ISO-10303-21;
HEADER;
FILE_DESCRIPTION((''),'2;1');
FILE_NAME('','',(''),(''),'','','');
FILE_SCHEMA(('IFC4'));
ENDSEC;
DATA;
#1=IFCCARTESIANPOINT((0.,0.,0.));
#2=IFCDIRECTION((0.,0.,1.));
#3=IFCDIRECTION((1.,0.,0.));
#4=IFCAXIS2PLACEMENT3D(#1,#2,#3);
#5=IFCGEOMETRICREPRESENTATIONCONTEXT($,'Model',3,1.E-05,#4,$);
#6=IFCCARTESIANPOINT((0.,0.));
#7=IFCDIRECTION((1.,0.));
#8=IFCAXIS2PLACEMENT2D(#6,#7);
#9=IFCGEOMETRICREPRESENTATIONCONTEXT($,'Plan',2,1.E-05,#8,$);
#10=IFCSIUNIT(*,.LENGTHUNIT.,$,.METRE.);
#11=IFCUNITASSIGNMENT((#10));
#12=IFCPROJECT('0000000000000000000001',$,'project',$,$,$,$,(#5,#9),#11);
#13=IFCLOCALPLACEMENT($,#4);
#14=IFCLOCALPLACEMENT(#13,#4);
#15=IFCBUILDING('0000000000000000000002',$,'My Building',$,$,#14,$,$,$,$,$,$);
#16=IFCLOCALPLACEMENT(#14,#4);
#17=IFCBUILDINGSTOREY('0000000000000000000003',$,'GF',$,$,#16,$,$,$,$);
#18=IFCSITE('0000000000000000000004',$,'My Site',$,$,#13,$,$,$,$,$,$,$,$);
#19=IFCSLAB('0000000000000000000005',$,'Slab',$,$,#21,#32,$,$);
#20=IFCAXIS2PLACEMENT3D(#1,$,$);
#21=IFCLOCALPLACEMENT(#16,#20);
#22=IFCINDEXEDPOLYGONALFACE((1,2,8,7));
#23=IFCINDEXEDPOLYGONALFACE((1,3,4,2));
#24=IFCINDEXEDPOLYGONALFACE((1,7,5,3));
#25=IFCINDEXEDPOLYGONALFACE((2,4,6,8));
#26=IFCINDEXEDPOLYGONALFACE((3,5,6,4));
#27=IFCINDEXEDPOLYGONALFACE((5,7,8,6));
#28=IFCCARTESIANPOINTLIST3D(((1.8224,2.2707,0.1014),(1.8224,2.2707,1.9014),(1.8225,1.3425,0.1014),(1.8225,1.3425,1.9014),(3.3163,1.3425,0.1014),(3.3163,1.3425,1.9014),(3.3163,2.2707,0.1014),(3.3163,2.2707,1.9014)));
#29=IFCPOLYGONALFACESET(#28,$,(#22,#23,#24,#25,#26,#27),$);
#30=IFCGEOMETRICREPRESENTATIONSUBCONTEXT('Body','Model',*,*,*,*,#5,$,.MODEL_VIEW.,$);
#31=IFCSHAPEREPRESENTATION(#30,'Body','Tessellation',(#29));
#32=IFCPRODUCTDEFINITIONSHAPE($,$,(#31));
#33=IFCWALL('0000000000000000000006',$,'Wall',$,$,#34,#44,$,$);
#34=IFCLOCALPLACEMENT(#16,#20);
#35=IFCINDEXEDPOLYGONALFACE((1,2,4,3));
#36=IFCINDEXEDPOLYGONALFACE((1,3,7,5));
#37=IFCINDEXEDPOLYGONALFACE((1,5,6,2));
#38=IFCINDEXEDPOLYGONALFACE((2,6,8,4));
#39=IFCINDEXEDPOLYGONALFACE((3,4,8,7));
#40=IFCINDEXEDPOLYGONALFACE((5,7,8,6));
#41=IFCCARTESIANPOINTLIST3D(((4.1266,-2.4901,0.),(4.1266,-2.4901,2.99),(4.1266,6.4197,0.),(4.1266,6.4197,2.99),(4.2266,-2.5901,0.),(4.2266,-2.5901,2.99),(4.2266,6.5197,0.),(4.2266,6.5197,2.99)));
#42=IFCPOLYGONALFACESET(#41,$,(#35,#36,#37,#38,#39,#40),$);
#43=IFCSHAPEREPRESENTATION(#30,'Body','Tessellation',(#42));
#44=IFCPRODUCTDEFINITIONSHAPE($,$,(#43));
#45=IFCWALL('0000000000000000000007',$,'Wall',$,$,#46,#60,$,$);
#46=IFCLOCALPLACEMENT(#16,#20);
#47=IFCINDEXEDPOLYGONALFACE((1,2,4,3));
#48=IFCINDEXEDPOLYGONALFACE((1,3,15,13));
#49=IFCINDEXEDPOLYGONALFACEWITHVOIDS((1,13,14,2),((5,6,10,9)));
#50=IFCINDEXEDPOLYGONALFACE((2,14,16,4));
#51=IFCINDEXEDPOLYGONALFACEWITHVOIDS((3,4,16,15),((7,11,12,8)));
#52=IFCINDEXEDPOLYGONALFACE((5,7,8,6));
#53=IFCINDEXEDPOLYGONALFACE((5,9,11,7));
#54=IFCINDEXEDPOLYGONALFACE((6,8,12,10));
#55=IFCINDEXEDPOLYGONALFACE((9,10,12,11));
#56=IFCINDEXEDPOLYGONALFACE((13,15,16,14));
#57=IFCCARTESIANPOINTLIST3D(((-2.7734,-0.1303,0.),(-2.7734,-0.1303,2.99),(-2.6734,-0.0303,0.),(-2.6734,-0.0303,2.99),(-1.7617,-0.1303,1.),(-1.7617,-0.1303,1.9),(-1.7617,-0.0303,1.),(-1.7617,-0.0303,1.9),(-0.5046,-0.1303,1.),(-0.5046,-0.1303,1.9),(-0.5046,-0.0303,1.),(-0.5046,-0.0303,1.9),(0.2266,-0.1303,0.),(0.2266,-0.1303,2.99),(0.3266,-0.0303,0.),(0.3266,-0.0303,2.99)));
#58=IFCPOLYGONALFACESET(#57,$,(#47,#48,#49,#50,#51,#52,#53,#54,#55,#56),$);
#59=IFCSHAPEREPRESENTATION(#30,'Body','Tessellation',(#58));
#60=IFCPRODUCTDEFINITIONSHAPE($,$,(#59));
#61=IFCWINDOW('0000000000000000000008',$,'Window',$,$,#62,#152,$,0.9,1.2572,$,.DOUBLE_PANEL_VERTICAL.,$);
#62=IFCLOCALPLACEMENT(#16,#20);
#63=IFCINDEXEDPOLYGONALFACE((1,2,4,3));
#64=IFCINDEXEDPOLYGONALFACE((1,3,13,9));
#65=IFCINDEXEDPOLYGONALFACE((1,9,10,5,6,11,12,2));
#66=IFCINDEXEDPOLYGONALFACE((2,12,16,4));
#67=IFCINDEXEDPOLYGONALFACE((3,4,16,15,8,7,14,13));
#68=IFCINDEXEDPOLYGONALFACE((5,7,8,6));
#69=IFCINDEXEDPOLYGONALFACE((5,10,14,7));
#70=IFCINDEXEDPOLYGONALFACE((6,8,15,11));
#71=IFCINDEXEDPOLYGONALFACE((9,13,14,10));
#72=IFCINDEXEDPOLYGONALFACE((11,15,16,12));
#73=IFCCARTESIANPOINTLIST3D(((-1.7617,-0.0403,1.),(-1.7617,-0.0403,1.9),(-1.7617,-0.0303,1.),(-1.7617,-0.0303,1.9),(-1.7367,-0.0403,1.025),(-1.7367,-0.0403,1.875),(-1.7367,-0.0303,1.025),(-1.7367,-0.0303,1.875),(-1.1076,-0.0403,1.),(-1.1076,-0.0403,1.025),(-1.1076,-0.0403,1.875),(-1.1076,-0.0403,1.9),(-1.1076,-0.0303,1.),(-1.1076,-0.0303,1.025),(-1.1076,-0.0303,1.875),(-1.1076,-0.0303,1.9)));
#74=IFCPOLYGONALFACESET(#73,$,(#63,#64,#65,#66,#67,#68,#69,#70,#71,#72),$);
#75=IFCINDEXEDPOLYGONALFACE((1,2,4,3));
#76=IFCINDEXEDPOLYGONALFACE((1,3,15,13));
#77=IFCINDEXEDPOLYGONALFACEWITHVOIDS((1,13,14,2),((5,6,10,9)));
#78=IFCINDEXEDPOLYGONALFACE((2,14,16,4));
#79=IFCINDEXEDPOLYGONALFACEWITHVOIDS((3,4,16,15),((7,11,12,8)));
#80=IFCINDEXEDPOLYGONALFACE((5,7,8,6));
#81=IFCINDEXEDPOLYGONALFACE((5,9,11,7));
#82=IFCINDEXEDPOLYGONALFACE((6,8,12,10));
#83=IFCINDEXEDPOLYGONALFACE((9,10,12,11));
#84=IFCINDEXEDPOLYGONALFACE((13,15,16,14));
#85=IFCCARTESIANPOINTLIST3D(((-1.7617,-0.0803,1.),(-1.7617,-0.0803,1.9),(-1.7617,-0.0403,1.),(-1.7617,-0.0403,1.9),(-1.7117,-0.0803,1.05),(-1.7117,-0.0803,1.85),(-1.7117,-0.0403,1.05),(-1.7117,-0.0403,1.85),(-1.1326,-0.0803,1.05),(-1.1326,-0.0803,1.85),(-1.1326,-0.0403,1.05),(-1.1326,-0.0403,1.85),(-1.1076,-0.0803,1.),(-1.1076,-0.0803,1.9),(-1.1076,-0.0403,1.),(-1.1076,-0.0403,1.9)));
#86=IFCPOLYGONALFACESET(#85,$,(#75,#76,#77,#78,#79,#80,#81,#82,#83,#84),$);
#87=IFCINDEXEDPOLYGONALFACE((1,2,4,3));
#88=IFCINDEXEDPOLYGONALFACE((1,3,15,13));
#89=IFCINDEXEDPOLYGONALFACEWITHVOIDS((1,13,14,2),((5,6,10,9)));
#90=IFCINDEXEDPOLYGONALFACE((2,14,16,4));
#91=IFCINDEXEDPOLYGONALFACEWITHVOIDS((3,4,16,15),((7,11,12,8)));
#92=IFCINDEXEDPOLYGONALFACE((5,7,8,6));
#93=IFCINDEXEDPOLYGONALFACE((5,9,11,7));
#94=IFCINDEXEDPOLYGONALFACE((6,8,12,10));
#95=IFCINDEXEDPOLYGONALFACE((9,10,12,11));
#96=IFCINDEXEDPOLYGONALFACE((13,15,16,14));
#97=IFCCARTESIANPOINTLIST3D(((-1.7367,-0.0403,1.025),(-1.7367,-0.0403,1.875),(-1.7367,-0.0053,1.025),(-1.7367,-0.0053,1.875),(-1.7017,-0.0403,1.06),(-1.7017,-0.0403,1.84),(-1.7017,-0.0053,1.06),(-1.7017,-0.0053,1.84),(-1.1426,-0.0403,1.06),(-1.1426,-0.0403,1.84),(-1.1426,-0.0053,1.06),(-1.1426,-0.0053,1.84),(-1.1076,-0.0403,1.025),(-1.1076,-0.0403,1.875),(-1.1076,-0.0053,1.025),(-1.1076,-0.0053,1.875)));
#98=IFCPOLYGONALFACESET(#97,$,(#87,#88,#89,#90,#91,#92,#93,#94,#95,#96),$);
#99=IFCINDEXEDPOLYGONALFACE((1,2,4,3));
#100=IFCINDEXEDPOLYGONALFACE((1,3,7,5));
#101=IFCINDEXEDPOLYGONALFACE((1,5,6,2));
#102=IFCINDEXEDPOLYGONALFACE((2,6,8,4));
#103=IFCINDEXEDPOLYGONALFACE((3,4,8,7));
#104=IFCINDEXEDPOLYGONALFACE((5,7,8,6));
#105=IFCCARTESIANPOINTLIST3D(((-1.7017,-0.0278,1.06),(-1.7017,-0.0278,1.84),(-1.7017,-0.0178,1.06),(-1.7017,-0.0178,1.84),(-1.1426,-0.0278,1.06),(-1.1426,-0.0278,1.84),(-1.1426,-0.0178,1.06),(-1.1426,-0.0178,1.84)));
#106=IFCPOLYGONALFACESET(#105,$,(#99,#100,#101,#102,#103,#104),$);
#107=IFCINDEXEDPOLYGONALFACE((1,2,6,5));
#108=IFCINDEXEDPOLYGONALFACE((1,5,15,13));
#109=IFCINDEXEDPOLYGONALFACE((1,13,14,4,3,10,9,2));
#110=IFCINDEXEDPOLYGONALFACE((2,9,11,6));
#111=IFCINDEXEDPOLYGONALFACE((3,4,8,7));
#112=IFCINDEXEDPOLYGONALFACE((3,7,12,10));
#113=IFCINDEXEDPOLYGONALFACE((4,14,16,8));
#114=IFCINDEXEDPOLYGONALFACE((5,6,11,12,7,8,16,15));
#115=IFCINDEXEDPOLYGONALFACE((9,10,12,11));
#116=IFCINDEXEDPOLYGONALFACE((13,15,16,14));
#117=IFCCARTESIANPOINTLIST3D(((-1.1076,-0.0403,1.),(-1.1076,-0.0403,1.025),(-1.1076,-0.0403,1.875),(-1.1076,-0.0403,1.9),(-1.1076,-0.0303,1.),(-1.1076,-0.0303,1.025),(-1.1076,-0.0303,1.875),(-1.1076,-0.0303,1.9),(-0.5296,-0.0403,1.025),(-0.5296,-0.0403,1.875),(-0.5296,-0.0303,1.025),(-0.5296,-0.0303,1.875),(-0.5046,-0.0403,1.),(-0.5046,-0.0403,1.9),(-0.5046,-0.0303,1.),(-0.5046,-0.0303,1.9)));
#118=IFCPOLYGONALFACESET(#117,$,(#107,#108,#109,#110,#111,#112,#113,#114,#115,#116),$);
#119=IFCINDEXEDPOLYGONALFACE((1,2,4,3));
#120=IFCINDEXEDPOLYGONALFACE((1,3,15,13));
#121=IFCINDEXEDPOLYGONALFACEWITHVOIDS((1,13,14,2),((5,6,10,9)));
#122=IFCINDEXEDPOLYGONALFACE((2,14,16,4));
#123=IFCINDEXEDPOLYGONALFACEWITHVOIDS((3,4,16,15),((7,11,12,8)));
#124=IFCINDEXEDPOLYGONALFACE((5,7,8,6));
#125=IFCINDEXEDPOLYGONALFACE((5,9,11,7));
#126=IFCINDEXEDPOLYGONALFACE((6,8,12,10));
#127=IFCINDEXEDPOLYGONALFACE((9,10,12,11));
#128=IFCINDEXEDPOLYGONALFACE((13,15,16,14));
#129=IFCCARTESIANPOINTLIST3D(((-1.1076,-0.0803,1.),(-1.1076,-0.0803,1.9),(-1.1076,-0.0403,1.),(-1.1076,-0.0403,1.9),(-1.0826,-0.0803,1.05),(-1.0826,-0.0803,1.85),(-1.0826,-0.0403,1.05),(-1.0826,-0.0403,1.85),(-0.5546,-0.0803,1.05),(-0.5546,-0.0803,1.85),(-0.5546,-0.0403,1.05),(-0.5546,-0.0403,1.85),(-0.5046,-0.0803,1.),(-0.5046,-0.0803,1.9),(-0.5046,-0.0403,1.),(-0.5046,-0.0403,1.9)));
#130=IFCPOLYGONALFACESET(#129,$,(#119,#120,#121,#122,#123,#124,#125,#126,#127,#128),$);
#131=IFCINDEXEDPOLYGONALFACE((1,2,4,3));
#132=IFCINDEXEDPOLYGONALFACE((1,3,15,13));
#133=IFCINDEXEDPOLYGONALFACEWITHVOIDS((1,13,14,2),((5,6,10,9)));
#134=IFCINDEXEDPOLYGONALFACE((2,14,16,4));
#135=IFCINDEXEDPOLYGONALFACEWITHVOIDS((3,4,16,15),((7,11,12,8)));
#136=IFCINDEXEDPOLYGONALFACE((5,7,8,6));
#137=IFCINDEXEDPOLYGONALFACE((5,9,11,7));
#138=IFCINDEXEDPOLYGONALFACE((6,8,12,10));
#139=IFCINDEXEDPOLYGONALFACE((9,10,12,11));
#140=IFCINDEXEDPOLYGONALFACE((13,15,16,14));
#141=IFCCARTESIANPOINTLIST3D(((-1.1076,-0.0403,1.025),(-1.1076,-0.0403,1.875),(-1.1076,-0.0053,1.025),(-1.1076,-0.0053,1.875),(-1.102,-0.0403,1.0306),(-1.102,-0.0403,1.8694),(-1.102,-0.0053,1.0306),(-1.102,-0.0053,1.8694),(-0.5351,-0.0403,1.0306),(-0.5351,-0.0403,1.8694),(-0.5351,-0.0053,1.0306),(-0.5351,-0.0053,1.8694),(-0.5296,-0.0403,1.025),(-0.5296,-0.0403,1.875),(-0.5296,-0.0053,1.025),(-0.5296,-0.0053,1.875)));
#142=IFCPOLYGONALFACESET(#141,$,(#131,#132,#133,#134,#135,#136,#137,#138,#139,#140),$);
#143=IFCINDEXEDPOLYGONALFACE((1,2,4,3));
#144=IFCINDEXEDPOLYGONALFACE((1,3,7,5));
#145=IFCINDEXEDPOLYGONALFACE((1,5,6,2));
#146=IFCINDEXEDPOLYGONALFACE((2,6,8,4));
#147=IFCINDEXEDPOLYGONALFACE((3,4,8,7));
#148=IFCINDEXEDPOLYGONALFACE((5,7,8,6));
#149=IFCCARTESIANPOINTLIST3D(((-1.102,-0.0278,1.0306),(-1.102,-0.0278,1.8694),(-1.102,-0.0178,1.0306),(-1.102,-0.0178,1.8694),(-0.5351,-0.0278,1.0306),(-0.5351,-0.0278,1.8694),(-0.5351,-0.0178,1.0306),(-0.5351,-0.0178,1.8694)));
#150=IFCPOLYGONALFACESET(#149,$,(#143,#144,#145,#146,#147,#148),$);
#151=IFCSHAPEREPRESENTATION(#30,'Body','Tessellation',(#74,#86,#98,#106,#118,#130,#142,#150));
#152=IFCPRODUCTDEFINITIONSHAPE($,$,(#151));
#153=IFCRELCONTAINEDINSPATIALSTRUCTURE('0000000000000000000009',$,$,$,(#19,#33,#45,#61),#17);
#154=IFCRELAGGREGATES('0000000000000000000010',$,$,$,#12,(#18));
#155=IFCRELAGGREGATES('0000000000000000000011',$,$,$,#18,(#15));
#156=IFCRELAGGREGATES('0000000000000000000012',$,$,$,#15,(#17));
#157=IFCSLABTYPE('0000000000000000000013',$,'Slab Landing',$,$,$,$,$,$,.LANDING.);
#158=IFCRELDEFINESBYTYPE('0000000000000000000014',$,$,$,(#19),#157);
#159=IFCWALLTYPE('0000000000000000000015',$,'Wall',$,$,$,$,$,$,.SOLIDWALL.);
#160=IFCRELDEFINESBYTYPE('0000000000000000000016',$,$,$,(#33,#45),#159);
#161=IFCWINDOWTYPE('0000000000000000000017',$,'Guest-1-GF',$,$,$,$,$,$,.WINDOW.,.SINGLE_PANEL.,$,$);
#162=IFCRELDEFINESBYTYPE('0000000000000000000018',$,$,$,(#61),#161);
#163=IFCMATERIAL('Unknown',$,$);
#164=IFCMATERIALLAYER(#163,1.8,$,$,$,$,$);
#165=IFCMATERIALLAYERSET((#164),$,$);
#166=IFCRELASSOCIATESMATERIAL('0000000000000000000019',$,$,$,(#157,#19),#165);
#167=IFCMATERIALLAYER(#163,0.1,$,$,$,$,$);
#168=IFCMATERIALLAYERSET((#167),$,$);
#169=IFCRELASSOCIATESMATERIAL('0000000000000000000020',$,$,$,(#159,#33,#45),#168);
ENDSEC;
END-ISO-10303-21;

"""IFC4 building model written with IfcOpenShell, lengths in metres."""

from ifc_helpers import new_model, entity, si_unit, frame, origin_with_axes, origin_2d_with_axis, place, context, subcontext, project, spatial, line, indexed_curve, outline, extrude, shape, source, transform, mapped, material, layer, layer_set, layer_usage, type_object, type_shapes, element, fill, save


model = new_model("IFC4")

# Units and contexts
model_context = context("Model", 3, precision=1e-05, world=origin_with_axes())
plan_context = context("Plan", 2, precision=1e-05, world=origin_2d_with_axis())
body_context_1 = subcontext(model_context, "Body", "Model", "MODEL_VIEW")
body_context_2 = subcontext(plan_context, "Body", "Plan", "PLAN_VIEW")
ifc_project = project(units=[si_unit("LENGTHUNIT", "METRE")], contexts=[model_context, plan_context])

# Site, building, storey
site_placement = place(None, origin_with_axes())
site = spatial("IfcSite", under=ifc_project, at=site_placement, Name="My Site")
building_placement = place(site_placement, origin_with_axes())
building = spatial("IfcBuilding", under=site, at=building_placement, Name="My Building")
storey_placement = place(building_placement, origin_with_axes())
storey = spatial("IfcBuildingStorey", under=building, at=storey_placement, Name="GF")

# Shared definitions
ifc_material = material(Name="Unknown")

# Slab
ifc_layer_1 = layer(ifc_material, 1.8)
ifc_layer_set_1 = layer_set([ifc_layer_1])
slab_type_1 = type_object("IfcSlabType", Name="Slab Landing", PredefinedType="LANDING", material=ifc_layer_set_1)
ifc_layer_usage_1 = layer_usage(ifc_layer_set_1, "AXIS3", "POSITIVE", -1.8)
slab_1_placement = place(storey_placement, frame((1.8225, 1.3425, 1.9014), z_axis=(0.0, 0.0, 1.0), x_axis=(1.0, 0.0, 0.0)))
element("IfcSlab", 1, at=slab_1_placement, inside=storey, type_object=slab_type_1, material=ifc_layer_usage_1, Name="Slab", context=body_context_1, shape_type="SweptSolid", body=[
    extrude(outline(indexed_curve([(0.0, 0.0), (1.4938, 0.0), (1.4938, 0.9282), (0.0, 0.9282), (0.0, 0.0)])), frame((0.0, 0.0, -1.8), z_axis=(0.0, 0.0, 1.0), x_axis=(1.0, 0.0, 0.0)), (0.0, 0.0, 1.0), 1.8),
])

# Shared definitions
ifc_layer_2 = layer(ifc_material, 0.1)
ifc_layer_set_2 = layer_set([ifc_layer_2])
wall_type = type_object("IfcWallType", Name="Wall", PredefinedType="SOLIDWALL", material=ifc_layer_set_2)

# Wall
ifc_layer_usage_2 = layer_usage(ifc_layer_set_2, "AXIS2", "POSITIVE", 0.0)
wall_1_placement = place(storey_placement, frame((4.2266, -2.5901, 0.0), z_axis=(0.0, 0.0, 1.0), x_axis=(0.0, 1.0, 0.0)))
element("IfcWall", 2, at=wall_1_placement, inside=storey, type_object=wall_type, material=ifc_layer_usage_2, Name="Wall", context=body_context_1, shape_type="SweptSolid", body=[
    extrude(outline(indexed_curve([(0.0, 0.0), (0.1, 0.1), (9.0098, 0.1), (9.1098, 0.0)], segments=[line(1, 2, 3, 4, 1)])), origin_with_axes(), (0.0, 0.0, 1.0), 2.99),
])

# Wall, opening, window
ifc_layer_usage_3 = layer_usage(ifc_layer_set_2, "AXIS2", "POSITIVE", 0.0)
wall_2_placement = place(storey_placement, frame((-2.7734, -0.1303, 0.0), z_axis=(0.0, 0.0, 1.0), x_axis=(1.0, 0.0, 0.0)))
wall_2 = element("IfcWall", 3, at=wall_2_placement, inside=storey, type_object=wall_type, material=ifc_layer_usage_3, Name="Wall", context=body_context_1, shape_type="SweptSolid", body=[
    extrude(outline(indexed_curve([(0.0, 0.0), (0.1, 0.1), (3.1, 0.1), (3.0, 0.0)], segments=[line(1, 2, 3, 4, 1)])), origin_with_axes(), (0.0, 0.0, 1.0), 2.99),
])
shared_shape_1 = source(origin_with_axes(), body_context_1, "Body", "SweptSolid", [
    extrude(outline(indexed_curve([(0.0, 0.0), (1.2572, 0.0), (1.2572, 0.9), (0.0, 0.9)], segments=[line(1, 2, 3, 4, 1)])), frame((0.0, -0.6, 0.0), z_axis=(0.0, -1.0, 0.0), x_axis=(1.0, 0.0, 0.0)), (0.0, 0.0, -1.0), 1.2),
])
opening_1_placement = place(wall_2_placement, frame((1.0116, 0.0, 1.0), z_axis=(0.0, 0.0, 1.0), x_axis=(1.0, 0.0, 0.0)))
opening_1 = element("IfcOpeningElement", 4, at=opening_1_placement, cuts=wall_2, PredefinedType="OPENING", context=body_context_1, shape_type="MappedRepresentation", body=[
    mapped(shared_shape_1, transform((0.0, 0.0, 0.0), x_axis=(1.0, 0.0, 0.0), y_axis=(0.0, 1.0, 0.0), z_axis=(0.0, 0.0, 1.0), scale=1.0)),
])
window_type_1 = type_object("IfcWindowType", Name="Guest-1-GF", PartitioningType="SINGLE_PANEL", PredefinedType="WINDOW")
shared_shape_2 = source(origin_with_axes(), body_context_1, "Body", "SweptSolid", [
    extrude(outline(indexed_curve([(0.6541, 0.0), (0.0, 0.0), (0.0, 0.9), (0.6541, 0.9), (0.6541, 0.875), (0.025, 0.875), (0.025, 0.025), (0.6541, 0.025)], segments=[line(1, 2, 3, 4, 5, 6, 7, 8, 1)])), frame((0.0, 0.09, 0.0), z_axis=(0.0, -1.0, 0.0), x_axis=(1.0, 0.0, 0.0)), (0.0, 0.0, -1.0), 0.01),
    extrude(outline(indexed_curve([(0.0, 0.0), (0.6541, 0.0), (0.6541, 0.9), (0.0, 0.9)], segments=[line(1, 2, 3, 4, 1)]), holes=[indexed_curve([(0.05, 0.05), (0.6291, 0.05), (0.6291, 0.85), (0.05, 0.85)], segments=[line(1, 2, 3, 4, 1)])]), frame((0.0, 0.05, 0.0), z_axis=(0.0, -1.0, 0.0), x_axis=(1.0, 0.0, 0.0)), (0.0, 0.0, -1.0), 0.04),
    extrude(outline(indexed_curve([(0.0, 0.0), (0.6291, 0.0), (0.6291, 0.85), (0.0, 0.85)], segments=[line(1, 2, 3, 4, 1)]), holes=[indexed_curve([(0.035, 0.035), (0.5941, 0.035), (0.5941, 0.815), (0.035, 0.815)], segments=[line(1, 2, 3, 4, 1)])]), frame((0.025, 0.09, 0.025), z_axis=(0.0, -1.0, 0.0), x_axis=(1.0, 0.0, 0.0)), (0.0, 0.0, -1.0), 0.035),
    extrude(outline(indexed_curve([(0.035, 0.035), (0.5941, 0.035), (0.5941, 0.815), (0.035, 0.815)], segments=[line(1, 2, 3, 4, 1)])), frame((0.025, 0.1025, 0.025), z_axis=(0.0, -1.0, 0.0), x_axis=(1.0, 0.0, 0.0)), (0.0, 0.0, -1.0), 0.01),
    extrude(outline(indexed_curve([(0.0, 0.9), (0.603, 0.9), (0.603, 0.0), (0.0, 0.0), (0.0, 0.025), (0.578, 0.025), (0.578, 0.875), (0.0, 0.875)], segments=[line(1, 2, 3, 4, 5, 6, 7, 8, 1)])), frame((0.6541, 0.09, 0.0), z_axis=(0.0, -1.0, 0.0), x_axis=(1.0, 0.0, 0.0)), (0.0, 0.0, -1.0), 0.01),
    extrude(outline(indexed_curve([(0.0, 0.0), (0.603, 0.0), (0.603, 0.9), (0.0, 0.9)], segments=[line(1, 2, 3, 4, 1)]), holes=[indexed_curve([(0.025, 0.05), (0.553, 0.05), (0.553, 0.85), (0.025, 0.85)], segments=[line(1, 2, 3, 4, 1)])]), frame((0.6541, 0.05, 0.0), z_axis=(0.0, -1.0, 0.0), x_axis=(1.0, 0.0, 0.0)), (0.0, 0.0, -1.0), 0.04),
    extrude(outline(indexed_curve([(0.0, 0.0), (0.578, 0.0), (0.578, 0.85), (0.0, 0.85)], segments=[line(1, 2, 3, 4, 1)]), holes=[indexed_curve([(0.0056, 0.0056), (0.5725, 0.0056), (0.5725, 0.8444), (0.0056, 0.8444)], segments=[line(1, 2, 3, 4, 1)])]), frame((0.6541, 0.09, 0.025), z_axis=(0.0, -1.0, 0.0), x_axis=(1.0, 0.0, 0.0)), (0.0, 0.0, -1.0), 0.035),
    extrude(outline(indexed_curve([(0.0056, 0.0056), (0.5725, 0.0056), (0.5725, 0.8444), (0.0056, 0.8444)], segments=[line(1, 2, 3, 4, 1)])), frame((0.6541, 0.1025, 0.025), z_axis=(0.0, -1.0, 0.0), x_axis=(1.0, 0.0, 0.0)), (0.0, 0.0, -1.0), 0.01),
])
shared_shape_3 = source(origin_with_axes(), body_context_2, "Body", "Curve2D", [
    entity("IfcIndexedPolyCurve", entity("IfcCartesianPointList2D", [[0.05, 0.05], [0.6291, 0.05]])),
    entity("IfcIndexedPolyCurve", entity("IfcCartesianPointList2D", [[0.0, 0.1], [0.025, 0.1], [0.025, 0.09], [0.05, 0.09], [0.05, 0.05], [0.0, 0.05]]), [entity("IfcLineIndex", [1, 2, 3, 4, 5, 6, 1])]),
    entity("IfcIndexedPolyCurve", entity("IfcCartesianPointList2D", [[0.6541, 0.1], [0.6541, 0.1], [0.6541, 0.09], [0.6291, 0.09], [0.6291, 0.05], [0.6541, 0.05]])),
    entity("IfcIndexedPolyCurve", entity("IfcCartesianPointList2D", [[0.025, 0.09], [0.06, 0.09], [0.06, 0.125], [0.025, 0.125]]), [entity("IfcLineIndex", [1, 2, 3, 4, 1])]),
    entity("IfcIndexedPolyCurve", entity("IfcCartesianPointList2D", [[0.6541, 0.09], [0.6191, 0.09], [0.6191, 0.125], [0.6541, 0.125]]), [entity("IfcLineIndex", [1, 2, 3, 4, 1])]),
    entity("IfcIndexedPolyCurve", entity("IfcCartesianPointList2D", [[0.06, 0.09], [0.6191, 0.09]])),
    entity("IfcIndexedPolyCurve", entity("IfcCartesianPointList2D", [[0.06, 0.125], [0.6191, 0.125]])),
    entity("IfcIndexedPolyCurve", entity("IfcCartesianPointList2D", [[0.06, 0.1075], [0.6191, 0.1075]])),
    entity("IfcIndexedPolyCurve", entity("IfcCartesianPointList2D", [[0.6791, 0.05], [1.2072, 0.05]])),
    entity("IfcIndexedPolyCurve", entity("IfcCartesianPointList2D", [[0.6541, 0.1], [0.6541, 0.1], [0.6541, 0.09], [0.6791, 0.09], [0.6791, 0.05], [0.6541, 0.05]])),
    entity("IfcIndexedPolyCurve", entity("IfcCartesianPointList2D", [[1.2572, 0.1], [1.2322, 0.1], [1.2322, 0.09], [1.2072, 0.09], [1.2072, 0.05], [1.2572, 0.05]]), [entity("IfcLineIndex", [1, 2, 3, 4, 5, 6, 1])]),
    entity("IfcIndexedPolyCurve", entity("IfcCartesianPointList2D", [[0.6541, 0.09], [0.6597, 0.09], [0.6597, 0.125], [0.6541, 0.125]]), [entity("IfcLineIndex", [1, 2, 3, 4, 1])]),
    entity("IfcIndexedPolyCurve", entity("IfcCartesianPointList2D", [[1.2322, 0.09], [1.2266, 0.09], [1.2266, 0.125], [1.2322, 0.125]]), [entity("IfcLineIndex", [1, 2, 3, 4, 1])]),
    entity("IfcIndexedPolyCurve", entity("IfcCartesianPointList2D", [[0.6597, 0.09], [1.2266, 0.09]])),
    entity("IfcIndexedPolyCurve", entity("IfcCartesianPointList2D", [[0.6597, 0.125], [1.2266, 0.125]])),
    entity("IfcIndexedPolyCurve", entity("IfcCartesianPointList2D", [[0.6597, 0.1075], [1.2266, 0.1075]])),
])
type_shapes(window_type_1, [shared_shape_2, shared_shape_3])
window_1_placement = place(opening_1_placement, frame((0.0, 0.0, 0.0), z_axis=(0.0, 0.0, 1.0), x_axis=(1.0, 0.0, 0.0)))
window_1 = element("IfcWindow", 5, at=window_1_placement, inside=storey, type_object=window_type_1, Name="Window", OverallHeight=0.9, OverallWidth=1.2572, PartitioningType="DOUBLE_PANEL_VERTICAL", shapes=[
    shape(body_context_1, "Body", "MappedRepresentation", [mapped(shared_shape_2, transform((0.0, 0.0, 0.0), x_axis=(1.0, 0.0, 0.0), y_axis=(0.0, 1.0, 0.0), z_axis=(0.0, 0.0, 1.0), scale=1.0))]),
    shape(body_context_2, "Body", "MappedRepresentation", [mapped(shared_shape_3, transform((0.0, 0.0, 0.0), x_axis=(1.0, 0.0, 0.0), y_axis=(0.0, 1.0, 0.0), z_axis=(0.0, 0.0, 1.0), scale=1.0))]),
])
fill(opening_1, window_1)

save(model, "model.ifc")
